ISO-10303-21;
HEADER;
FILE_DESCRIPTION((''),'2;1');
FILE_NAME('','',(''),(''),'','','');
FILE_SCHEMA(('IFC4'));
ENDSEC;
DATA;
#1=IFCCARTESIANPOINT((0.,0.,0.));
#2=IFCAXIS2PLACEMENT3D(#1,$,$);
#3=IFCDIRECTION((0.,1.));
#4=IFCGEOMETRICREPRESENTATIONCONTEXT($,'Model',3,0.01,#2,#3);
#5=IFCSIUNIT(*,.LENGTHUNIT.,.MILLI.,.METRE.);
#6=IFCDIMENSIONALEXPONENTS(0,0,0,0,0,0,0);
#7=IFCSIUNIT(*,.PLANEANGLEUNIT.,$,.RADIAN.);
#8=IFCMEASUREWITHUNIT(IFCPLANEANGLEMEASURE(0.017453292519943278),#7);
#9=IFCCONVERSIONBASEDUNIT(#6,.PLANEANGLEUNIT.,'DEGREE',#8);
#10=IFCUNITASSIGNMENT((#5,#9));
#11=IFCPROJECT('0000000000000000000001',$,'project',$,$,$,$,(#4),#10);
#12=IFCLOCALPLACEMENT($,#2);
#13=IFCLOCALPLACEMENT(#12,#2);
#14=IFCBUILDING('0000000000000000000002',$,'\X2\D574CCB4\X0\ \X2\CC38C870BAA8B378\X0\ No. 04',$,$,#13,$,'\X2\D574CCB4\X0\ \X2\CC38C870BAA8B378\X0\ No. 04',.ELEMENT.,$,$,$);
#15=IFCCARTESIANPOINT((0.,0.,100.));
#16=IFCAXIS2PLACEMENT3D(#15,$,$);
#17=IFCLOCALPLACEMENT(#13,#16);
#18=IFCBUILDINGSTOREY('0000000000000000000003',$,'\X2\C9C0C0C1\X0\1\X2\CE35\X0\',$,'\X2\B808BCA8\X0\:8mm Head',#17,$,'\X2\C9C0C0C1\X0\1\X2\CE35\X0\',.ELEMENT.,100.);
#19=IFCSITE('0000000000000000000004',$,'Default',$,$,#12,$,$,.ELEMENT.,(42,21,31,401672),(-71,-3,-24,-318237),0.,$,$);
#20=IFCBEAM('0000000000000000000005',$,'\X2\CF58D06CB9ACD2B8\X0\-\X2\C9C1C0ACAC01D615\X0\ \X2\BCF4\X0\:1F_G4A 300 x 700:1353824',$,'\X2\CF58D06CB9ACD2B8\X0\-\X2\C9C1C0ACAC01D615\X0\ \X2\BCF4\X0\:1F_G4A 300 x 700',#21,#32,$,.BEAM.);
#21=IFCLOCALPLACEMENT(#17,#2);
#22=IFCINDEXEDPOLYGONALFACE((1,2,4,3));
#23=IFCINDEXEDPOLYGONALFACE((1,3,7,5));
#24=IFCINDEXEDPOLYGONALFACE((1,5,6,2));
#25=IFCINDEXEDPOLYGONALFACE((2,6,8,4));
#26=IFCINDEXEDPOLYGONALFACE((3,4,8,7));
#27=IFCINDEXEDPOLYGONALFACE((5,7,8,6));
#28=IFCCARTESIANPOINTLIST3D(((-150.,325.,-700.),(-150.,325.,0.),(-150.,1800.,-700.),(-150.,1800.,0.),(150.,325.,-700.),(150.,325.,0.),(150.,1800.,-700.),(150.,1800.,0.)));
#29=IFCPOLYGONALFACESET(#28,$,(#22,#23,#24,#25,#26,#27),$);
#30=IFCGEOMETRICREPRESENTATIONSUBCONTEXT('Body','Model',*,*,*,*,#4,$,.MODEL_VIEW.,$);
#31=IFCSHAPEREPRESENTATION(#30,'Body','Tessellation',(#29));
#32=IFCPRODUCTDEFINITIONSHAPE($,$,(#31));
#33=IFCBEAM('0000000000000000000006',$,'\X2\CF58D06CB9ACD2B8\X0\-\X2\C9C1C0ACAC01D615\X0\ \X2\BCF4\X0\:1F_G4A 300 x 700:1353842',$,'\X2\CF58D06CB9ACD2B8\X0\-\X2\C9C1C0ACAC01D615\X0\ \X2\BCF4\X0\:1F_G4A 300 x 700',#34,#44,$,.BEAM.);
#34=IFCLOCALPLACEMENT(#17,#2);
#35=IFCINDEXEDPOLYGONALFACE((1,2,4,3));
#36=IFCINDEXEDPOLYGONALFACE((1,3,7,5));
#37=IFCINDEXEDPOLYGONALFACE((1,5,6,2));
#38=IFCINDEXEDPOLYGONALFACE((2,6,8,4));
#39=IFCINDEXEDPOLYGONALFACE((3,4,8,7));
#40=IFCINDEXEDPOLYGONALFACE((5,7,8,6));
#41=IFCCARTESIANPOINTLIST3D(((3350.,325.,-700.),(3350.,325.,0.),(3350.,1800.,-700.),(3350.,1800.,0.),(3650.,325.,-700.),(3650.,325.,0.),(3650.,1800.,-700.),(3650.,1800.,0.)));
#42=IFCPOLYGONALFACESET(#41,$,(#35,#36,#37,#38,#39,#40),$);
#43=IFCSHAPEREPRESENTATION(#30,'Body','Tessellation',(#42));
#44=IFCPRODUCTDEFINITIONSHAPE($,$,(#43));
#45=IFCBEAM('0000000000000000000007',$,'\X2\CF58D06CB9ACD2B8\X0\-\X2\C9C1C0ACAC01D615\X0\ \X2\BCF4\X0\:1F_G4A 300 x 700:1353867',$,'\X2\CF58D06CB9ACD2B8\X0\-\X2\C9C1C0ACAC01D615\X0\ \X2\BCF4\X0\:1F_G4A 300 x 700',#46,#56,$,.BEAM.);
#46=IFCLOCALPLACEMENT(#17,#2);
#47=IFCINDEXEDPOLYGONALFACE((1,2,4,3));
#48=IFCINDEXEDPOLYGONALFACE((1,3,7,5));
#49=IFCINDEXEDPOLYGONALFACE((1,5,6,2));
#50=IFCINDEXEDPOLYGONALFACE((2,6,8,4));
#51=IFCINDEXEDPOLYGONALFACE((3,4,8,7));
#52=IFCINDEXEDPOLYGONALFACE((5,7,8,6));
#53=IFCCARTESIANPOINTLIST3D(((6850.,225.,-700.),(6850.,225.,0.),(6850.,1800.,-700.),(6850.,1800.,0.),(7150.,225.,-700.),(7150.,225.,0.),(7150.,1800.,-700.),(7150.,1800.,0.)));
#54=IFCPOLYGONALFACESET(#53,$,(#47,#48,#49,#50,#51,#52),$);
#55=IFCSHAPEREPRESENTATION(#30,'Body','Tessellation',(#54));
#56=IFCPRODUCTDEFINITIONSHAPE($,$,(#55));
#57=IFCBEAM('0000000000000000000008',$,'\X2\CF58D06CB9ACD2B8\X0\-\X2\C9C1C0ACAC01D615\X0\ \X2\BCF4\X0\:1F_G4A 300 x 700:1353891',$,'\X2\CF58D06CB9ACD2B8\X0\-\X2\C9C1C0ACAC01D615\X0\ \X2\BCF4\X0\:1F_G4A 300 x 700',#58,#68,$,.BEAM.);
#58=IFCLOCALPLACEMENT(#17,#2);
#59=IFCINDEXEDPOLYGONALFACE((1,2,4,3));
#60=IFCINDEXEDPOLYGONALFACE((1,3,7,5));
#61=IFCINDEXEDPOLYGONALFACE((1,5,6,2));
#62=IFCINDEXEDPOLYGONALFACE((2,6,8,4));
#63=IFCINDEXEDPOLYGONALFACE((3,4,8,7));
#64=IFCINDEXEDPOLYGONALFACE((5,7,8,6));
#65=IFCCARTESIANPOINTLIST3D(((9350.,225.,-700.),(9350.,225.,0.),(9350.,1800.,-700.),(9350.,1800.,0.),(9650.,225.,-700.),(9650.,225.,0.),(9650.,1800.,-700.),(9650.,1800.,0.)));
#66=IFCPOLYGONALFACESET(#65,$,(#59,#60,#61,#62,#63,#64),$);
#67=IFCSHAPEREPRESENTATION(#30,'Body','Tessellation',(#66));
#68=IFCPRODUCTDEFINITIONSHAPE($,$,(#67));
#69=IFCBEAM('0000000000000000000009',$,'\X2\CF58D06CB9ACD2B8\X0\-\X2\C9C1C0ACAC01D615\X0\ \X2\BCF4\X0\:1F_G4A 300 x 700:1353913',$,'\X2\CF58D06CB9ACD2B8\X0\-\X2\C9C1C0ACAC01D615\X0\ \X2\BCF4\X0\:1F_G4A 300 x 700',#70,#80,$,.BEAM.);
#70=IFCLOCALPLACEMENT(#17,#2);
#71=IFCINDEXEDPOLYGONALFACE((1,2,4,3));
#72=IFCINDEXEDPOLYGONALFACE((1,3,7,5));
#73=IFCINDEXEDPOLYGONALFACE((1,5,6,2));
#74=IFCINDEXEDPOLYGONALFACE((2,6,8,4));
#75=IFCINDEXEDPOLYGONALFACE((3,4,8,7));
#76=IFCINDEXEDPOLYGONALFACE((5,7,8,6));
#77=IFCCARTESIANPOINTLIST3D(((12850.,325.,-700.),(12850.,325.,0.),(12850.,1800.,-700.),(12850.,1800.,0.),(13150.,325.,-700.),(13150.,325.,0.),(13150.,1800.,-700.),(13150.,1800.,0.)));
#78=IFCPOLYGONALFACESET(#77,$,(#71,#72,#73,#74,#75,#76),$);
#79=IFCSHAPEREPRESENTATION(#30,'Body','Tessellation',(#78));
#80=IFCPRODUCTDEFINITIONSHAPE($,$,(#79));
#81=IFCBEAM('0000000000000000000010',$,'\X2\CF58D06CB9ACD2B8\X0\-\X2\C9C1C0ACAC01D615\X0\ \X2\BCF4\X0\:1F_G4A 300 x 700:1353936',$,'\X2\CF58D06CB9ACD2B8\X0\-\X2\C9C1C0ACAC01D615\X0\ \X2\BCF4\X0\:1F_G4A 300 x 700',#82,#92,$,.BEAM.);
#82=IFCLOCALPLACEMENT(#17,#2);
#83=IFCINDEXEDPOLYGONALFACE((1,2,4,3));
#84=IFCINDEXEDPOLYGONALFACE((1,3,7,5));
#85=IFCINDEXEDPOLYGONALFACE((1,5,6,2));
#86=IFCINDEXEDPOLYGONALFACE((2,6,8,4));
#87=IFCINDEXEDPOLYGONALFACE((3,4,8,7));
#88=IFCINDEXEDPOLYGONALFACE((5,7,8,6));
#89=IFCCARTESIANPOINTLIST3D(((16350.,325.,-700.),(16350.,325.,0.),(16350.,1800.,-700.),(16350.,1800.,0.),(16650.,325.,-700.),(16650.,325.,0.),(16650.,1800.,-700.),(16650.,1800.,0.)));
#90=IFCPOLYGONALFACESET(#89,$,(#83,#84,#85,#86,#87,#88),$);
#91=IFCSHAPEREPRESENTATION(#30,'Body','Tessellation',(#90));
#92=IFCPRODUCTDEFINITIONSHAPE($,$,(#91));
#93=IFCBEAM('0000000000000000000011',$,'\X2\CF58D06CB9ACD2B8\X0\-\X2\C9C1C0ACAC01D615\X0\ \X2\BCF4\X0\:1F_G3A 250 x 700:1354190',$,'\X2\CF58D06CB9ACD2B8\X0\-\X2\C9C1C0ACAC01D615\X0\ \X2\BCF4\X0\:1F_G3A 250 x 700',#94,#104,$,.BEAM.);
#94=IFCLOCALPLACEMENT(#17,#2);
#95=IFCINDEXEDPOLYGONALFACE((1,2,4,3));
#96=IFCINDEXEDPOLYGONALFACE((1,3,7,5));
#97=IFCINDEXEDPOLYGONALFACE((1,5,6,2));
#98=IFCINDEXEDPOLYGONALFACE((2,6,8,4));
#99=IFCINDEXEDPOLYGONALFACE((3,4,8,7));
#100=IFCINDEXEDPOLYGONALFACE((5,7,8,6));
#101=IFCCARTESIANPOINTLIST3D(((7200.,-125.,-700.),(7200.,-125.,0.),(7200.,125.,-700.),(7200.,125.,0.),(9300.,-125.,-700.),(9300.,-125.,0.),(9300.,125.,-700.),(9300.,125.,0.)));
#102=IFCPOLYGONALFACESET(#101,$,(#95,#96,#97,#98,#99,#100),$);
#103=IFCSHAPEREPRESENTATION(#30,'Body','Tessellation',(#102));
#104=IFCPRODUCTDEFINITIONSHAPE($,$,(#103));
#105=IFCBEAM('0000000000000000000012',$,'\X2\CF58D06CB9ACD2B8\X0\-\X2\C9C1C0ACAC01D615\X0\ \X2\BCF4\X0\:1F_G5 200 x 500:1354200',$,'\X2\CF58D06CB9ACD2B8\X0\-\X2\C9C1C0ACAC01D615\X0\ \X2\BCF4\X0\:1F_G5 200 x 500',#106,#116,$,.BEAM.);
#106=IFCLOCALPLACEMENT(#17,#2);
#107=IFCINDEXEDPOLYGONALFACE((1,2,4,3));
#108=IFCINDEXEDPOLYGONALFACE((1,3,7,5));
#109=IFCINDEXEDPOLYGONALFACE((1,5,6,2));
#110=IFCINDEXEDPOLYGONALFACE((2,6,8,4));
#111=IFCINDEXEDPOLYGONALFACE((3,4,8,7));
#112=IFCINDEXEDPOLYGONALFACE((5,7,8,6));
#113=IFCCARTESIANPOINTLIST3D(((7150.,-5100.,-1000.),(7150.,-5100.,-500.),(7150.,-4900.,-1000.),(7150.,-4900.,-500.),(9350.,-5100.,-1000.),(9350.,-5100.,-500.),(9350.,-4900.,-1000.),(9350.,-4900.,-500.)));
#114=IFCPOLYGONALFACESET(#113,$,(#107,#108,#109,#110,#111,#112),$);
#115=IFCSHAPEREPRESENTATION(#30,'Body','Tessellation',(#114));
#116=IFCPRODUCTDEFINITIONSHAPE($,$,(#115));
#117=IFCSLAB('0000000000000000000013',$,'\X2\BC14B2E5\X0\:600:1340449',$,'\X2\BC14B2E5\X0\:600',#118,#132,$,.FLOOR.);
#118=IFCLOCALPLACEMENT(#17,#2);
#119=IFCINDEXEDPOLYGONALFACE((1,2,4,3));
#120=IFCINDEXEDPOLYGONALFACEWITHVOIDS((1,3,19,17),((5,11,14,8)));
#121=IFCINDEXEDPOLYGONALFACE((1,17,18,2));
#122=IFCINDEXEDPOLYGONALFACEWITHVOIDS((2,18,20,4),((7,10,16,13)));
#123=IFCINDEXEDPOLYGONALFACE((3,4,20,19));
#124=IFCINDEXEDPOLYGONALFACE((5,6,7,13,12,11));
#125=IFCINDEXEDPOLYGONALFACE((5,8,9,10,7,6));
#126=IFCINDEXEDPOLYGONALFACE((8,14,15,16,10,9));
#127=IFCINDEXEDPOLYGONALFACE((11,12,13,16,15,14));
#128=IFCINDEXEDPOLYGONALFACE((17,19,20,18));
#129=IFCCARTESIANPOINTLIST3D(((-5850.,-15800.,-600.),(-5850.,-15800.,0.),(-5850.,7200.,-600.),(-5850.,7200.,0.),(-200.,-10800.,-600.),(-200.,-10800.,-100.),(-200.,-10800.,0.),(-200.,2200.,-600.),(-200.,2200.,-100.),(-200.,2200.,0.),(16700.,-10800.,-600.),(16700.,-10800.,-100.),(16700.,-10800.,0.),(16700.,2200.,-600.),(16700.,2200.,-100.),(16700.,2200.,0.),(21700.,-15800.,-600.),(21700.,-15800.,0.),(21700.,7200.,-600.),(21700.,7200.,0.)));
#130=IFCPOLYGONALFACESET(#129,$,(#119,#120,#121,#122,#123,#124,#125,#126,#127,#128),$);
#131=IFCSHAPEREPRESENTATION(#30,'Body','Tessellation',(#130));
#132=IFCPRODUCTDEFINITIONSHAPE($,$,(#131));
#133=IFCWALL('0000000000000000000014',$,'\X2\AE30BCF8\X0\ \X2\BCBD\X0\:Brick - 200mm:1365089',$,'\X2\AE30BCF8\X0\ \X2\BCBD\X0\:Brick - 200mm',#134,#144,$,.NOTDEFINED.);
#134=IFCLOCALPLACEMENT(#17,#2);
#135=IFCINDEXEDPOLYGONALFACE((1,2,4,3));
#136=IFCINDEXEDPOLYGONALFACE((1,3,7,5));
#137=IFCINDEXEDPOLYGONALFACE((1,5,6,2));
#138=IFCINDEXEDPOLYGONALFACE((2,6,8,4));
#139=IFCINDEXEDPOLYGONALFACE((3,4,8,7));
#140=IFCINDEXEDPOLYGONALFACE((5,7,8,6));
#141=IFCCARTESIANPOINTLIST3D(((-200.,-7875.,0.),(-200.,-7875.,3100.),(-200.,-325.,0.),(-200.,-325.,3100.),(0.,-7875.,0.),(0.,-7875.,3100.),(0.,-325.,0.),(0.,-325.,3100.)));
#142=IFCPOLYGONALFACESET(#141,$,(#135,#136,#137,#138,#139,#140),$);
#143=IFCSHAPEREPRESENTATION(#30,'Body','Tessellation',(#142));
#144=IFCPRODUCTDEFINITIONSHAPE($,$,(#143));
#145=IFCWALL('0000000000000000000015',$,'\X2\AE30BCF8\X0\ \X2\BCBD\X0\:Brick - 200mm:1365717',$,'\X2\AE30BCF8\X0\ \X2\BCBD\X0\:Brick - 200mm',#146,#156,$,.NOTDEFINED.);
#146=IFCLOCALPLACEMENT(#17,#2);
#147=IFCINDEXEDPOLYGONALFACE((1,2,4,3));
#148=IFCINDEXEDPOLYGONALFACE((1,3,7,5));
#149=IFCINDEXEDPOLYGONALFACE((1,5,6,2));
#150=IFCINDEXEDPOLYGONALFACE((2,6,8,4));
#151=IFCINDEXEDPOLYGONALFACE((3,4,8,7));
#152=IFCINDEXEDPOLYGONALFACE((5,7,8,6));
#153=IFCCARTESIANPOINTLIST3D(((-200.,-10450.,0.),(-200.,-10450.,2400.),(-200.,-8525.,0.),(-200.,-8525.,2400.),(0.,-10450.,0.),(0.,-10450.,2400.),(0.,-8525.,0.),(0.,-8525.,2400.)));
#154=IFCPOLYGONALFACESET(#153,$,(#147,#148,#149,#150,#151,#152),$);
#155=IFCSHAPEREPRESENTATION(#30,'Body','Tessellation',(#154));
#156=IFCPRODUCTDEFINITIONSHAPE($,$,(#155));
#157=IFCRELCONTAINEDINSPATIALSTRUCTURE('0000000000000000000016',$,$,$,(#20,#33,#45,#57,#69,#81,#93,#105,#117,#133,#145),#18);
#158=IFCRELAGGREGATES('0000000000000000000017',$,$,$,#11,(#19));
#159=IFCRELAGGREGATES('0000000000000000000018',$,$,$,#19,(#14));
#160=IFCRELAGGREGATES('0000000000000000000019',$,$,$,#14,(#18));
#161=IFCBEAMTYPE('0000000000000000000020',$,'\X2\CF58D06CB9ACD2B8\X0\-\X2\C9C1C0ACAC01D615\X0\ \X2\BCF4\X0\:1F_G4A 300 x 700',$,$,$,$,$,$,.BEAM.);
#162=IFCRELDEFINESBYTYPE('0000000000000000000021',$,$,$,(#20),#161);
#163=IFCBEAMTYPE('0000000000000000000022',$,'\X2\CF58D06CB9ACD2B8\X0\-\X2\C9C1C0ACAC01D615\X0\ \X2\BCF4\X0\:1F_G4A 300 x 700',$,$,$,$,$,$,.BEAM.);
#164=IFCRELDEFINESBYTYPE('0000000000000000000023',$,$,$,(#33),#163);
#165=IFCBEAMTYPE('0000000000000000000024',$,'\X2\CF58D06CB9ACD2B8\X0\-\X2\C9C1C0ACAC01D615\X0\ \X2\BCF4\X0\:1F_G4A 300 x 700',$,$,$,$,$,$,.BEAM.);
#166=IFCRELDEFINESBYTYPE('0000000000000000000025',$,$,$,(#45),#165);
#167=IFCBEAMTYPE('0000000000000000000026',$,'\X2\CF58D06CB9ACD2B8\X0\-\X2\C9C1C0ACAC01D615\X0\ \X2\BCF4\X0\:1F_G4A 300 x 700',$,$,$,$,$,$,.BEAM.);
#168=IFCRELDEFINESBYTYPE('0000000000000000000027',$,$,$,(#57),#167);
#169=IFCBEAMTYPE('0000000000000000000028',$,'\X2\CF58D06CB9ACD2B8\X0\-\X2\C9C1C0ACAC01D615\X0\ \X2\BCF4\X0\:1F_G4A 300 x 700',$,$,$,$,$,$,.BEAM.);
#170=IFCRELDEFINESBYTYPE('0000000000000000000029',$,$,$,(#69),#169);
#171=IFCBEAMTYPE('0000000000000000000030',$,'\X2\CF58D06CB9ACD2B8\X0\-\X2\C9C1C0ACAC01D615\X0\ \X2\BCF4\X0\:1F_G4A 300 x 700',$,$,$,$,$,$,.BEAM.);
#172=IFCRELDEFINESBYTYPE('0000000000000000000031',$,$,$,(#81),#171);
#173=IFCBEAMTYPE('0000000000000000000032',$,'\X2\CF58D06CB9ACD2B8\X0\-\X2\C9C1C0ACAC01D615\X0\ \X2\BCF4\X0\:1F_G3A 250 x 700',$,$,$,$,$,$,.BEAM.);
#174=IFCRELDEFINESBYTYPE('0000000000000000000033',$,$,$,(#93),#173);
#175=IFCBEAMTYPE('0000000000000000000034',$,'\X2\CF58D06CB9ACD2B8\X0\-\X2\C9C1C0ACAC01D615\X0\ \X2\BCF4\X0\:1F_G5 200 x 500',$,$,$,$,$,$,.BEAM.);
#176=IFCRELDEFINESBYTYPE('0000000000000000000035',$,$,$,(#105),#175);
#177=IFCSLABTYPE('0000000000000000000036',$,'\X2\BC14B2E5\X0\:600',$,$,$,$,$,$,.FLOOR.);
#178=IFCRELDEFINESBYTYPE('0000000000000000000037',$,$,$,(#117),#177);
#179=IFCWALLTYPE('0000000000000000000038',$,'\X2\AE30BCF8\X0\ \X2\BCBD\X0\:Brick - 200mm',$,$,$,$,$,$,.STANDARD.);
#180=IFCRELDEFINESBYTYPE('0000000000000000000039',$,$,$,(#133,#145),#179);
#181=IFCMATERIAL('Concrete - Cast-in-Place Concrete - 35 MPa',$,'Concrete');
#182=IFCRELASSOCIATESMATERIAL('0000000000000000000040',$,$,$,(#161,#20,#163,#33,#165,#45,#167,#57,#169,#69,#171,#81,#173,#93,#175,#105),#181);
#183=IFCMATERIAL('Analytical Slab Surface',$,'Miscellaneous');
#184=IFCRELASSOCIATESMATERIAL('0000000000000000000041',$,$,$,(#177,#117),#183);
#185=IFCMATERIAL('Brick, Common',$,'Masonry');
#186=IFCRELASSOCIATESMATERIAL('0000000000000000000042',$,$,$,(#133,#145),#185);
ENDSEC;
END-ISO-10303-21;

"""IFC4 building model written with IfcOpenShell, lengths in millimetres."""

from ifc_helpers import new_model, entity, si_unit, converted_unit, direction, frame, origin, place, context, subcontext, project, spatial, indexed_curve, outline, extrude, source, transform, mapped, material, type_object, type_shapes, element, save


model = new_model("IFC4")

# Units and contexts
model_context = context("Model", 3, precision=0.01, world=origin(), true_north=direction((0.0, 1.0)))
body_context = subcontext(model_context, "Body", "Model", "MODEL_VIEW")
ifc_project = project(units=[si_unit("LENGTHUNIT", "METRE", prefix="MILLI"), converted_unit("PLANEANGLEUNIT", "DEGREE", entity("IfcPlaneAngleMeasure", 0.017453292519943278), si_unit("PLANEANGLEUNIT", "RADIAN"), dimensions=[0, 0, 0, 0, 0, 0, 0])], contexts=[model_context])

# Site, building, storey
site_placement = place(None, origin())
site = spatial("IfcSite", under=ifc_project, at=site_placement, Name="Default", CompositionType="ELEMENT", RefLatitude=(42, 21, 31, 401672), RefLongitude=(-71, -3, -24, -318237), RefElevation=0.0)
building_placement = place(site_placement, origin())
building = spatial("IfcBuilding", under=site, at=building_placement, Name="해체 참조모델 No. 04", LongName="해체 참조모델 No. 04", CompositionType="ELEMENT")
storey_placement = place(building_placement, frame((0.0, 0.0, 100.0)))
storey = spatial("IfcBuildingStorey", under=building, at=storey_placement, Name="지상1층", ObjectType="레벨:8mm Head", LongName="지상1층", CompositionType="ELEMENT", Elevation=100.0)

# Beams
ifc_material_1 = material(Name="Concrete - Cast-in-Place Concrete - 35 MPa", Category="Concrete")
beam_type_1 = type_object("IfcBeamType", Name="콘크리트-직사각형 보:1F_G4A 300 x 700", PredefinedType="BEAM", material=ifc_material_1)
shared_shape_1 = source(origin(), body_context, "Body", "SweptSolid", [
    extrude(outline(indexed_curve([(-150.0, -350.0), (150.0, -350.0), (150.0, 350.0), (-150.0, 350.0), (-150.0, -350.0)], self_intersect=False)), frame((0.0, 325.0, -250.0), z_axis=(0.0, 1.0, 0.0), x_axis=(-1.0, 0.0, 0.0)), (0.0, 0.0, 1.0), 1475.0),
])
type_shapes(beam_type_1, [shared_shape_1])
beam_1_placement = place(storey_placement, frame((0.0, 0.0, -100.0)))
element("IfcBeam", 1, at=beam_1_placement, inside=storey, type_object=beam_type_1, material=ifc_material_1, Name="콘크리트-직사각형 보:1F_G4A 300 x 700:1353824", ObjectType="콘크리트-직사각형 보:1F_G4A 300 x 700", PredefinedType="BEAM", context=body_context, shape_type="MappedRepresentation", body=[
    mapped(shared_shape_1, transform((0.0, 0.0, 0.0), scale=1.0)),
])
beam_type_2 = type_object("IfcBeamType", Name="콘크리트-직사각형 보:1F_G4A 300 x 700", PredefinedType="BEAM", material=ifc_material_1)
shared_shape_2 = source(origin(), body_context, "Body", "SweptSolid", [
    extrude(outline(indexed_curve([(-150.0, -350.0), (150.0, -350.0), (150.0, 350.0), (-150.0, 350.0), (-150.0, -350.0)], self_intersect=False)), frame((3500.0, 325.0, -250.0), z_axis=(0.0, 1.0, 0.0), x_axis=(-1.0, 0.0, 0.0)), (0.0, 0.0, 1.0), 1475.0),
])
type_shapes(beam_type_2, [shared_shape_2])
beam_2_placement = place(storey_placement, frame((0.0, 0.0, -100.0)))
element("IfcBeam", 2, at=beam_2_placement, inside=storey, type_object=beam_type_2, material=ifc_material_1, Name="콘크리트-직사각형 보:1F_G4A 300 x 700:1353842", ObjectType="콘크리트-직사각형 보:1F_G4A 300 x 700", PredefinedType="BEAM", context=body_context, shape_type="MappedRepresentation", body=[
    mapped(shared_shape_2, transform((0.0, 0.0, 0.0), scale=1.0)),
])
beam_type_3 = type_object("IfcBeamType", Name="콘크리트-직사각형 보:1F_G4A 300 x 700", PredefinedType="BEAM", material=ifc_material_1)
shared_shape_3 = source(origin(), body_context, "Body", "SweptSolid", [
    extrude(outline(indexed_curve([(-150.0, -350.0), (150.0, -350.0), (150.0, 350.0), (-150.0, 350.0), (-150.0, -350.0)], self_intersect=False)), frame((7000.0, 225.0, -250.0), z_axis=(0.0, 1.0, 0.0), x_axis=(-1.0, 0.0, 0.0)), (0.0, 0.0, 1.0), 1575.0),
])
type_shapes(beam_type_3, [shared_shape_3])
beam_3_placement = place(storey_placement, frame((0.0, 0.0, -100.0)))
element("IfcBeam", 3, at=beam_3_placement, inside=storey, type_object=beam_type_3, material=ifc_material_1, Name="콘크리트-직사각형 보:1F_G4A 300 x 700:1353867", ObjectType="콘크리트-직사각형 보:1F_G4A 300 x 700", PredefinedType="BEAM", context=body_context, shape_type="MappedRepresentation", body=[
    mapped(shared_shape_3, transform((0.0, 0.0, 0.0), scale=1.0)),
])
beam_type_4 = type_object("IfcBeamType", Name="콘크리트-직사각형 보:1F_G4A 300 x 700", PredefinedType="BEAM", material=ifc_material_1)
shared_shape_4 = source(origin(), body_context, "Body", "SweptSolid", [
    extrude(outline(indexed_curve([(-150.0, -350.0), (150.0, -350.0), (150.0, 350.0), (-150.0, 350.0), (-150.0, -350.0)], self_intersect=False)), frame((9500.0, 225.0, -250.0), z_axis=(0.0, 1.0, 0.0), x_axis=(-1.0, 0.0, 0.0)), (0.0, 0.0, 1.0), 1575.0),
])
type_shapes(beam_type_4, [shared_shape_4])
beam_4_placement = place(storey_placement, frame((0.0, 0.0, -100.0)))
element("IfcBeam", 4, at=beam_4_placement, inside=storey, type_object=beam_type_4, material=ifc_material_1, Name="콘크리트-직사각형 보:1F_G4A 300 x 700:1353891", ObjectType="콘크리트-직사각형 보:1F_G4A 300 x 700", PredefinedType="BEAM", context=body_context, shape_type="MappedRepresentation", body=[
    mapped(shared_shape_4, transform((0.0, 0.0, 0.0), scale=1.0)),
])
beam_type_5 = type_object("IfcBeamType", Name="콘크리트-직사각형 보:1F_G4A 300 x 700", PredefinedType="BEAM", material=ifc_material_1)
shared_shape_5 = source(origin(), body_context, "Body", "SweptSolid", [
    extrude(outline(indexed_curve([(-150.0, -350.0), (150.0, -350.0), (150.0, 350.0), (-150.0, 350.0), (-150.0, -350.0)], self_intersect=False)), frame((13000.0, 325.0, -250.0), z_axis=(0.0, 1.0, 0.0), x_axis=(-1.0, 0.0, 0.0)), (0.0, 0.0, 1.0), 1475.0),
])
type_shapes(beam_type_5, [shared_shape_5])
beam_5_placement = place(storey_placement, frame((0.0, 0.0, -100.0)))
element("IfcBeam", 5, at=beam_5_placement, inside=storey, type_object=beam_type_5, material=ifc_material_1, Name="콘크리트-직사각형 보:1F_G4A 300 x 700:1353913", ObjectType="콘크리트-직사각형 보:1F_G4A 300 x 700", PredefinedType="BEAM", context=body_context, shape_type="MappedRepresentation", body=[
    mapped(shared_shape_5, transform((0.0, 0.0, 0.0), scale=1.0)),
])
beam_type_6 = type_object("IfcBeamType", Name="콘크리트-직사각형 보:1F_G4A 300 x 700", PredefinedType="BEAM", material=ifc_material_1)
shared_shape_6 = source(origin(), body_context, "Body", "SweptSolid", [
    extrude(outline(indexed_curve([(-150.0, -350.0), (150.0, -350.0), (150.0, 350.0), (-150.0, 350.0), (-150.0, -350.0)], self_intersect=False)), frame((16500.0, 325.0, -250.0), z_axis=(0.0, 1.0, 0.0), x_axis=(-1.0, 0.0, 0.0)), (0.0, 0.0, 1.0), 1475.0),
])
type_shapes(beam_type_6, [shared_shape_6])
beam_6_placement = place(storey_placement, frame((0.0, 0.0, -100.0)))
element("IfcBeam", 6, at=beam_6_placement, inside=storey, type_object=beam_type_6, material=ifc_material_1, Name="콘크리트-직사각형 보:1F_G4A 300 x 700:1353936", ObjectType="콘크리트-직사각형 보:1F_G4A 300 x 700", PredefinedType="BEAM", context=body_context, shape_type="MappedRepresentation", body=[
    mapped(shared_shape_6, transform((0.0, 0.0, 0.0), scale=1.0)),
])
beam_type_7 = type_object("IfcBeamType", Name="콘크리트-직사각형 보:1F_G3A 250 x 700", PredefinedType="BEAM", material=ifc_material_1)
shared_shape_7 = source(origin(), body_context, "Body", "SweptSolid", [
    extrude(outline(indexed_curve([(-350.0, -125.0), (350.0, -125.0), (350.0, 125.0), (-350.0, 125.0), (-350.0, -125.0)], self_intersect=False)), frame((7200.0, 0.0, -250.0), z_axis=(1.0, 0.0, 0.0), x_axis=(0.0, 0.0, -1.0)), (0.0, 0.0, 1.0), 2100.0),
])
type_shapes(beam_type_7, [shared_shape_7])
beam_7_placement = place(storey_placement, frame((0.0, 0.0, -100.0)))
element("IfcBeam", 7, at=beam_7_placement, inside=storey, type_object=beam_type_7, material=ifc_material_1, Name="콘크리트-직사각형 보:1F_G3A 250 x 700:1354190", ObjectType="콘크리트-직사각형 보:1F_G3A 250 x 700", PredefinedType="BEAM", context=body_context, shape_type="MappedRepresentation", body=[
    mapped(shared_shape_7, transform((0.0, 0.0, 0.0), scale=1.0)),
])
beam_type_8 = type_object("IfcBeamType", Name="콘크리트-직사각형 보:1F_G5 200 x 500", PredefinedType="BEAM", material=ifc_material_1)
shared_shape_8 = source(origin(), body_context, "Body", "SweptSolid", [
    extrude(outline(indexed_curve([(-250.0, -100.0), (250.0, -100.0), (250.0, 100.0), (-250.0, 100.0), (-250.0, -100.0)], self_intersect=False)), frame((7150.0, -5000.0, -650.0), z_axis=(1.0, 0.0, 0.0), x_axis=(0.0, 0.0, -1.0)), (0.0, 0.0, 1.0), 2200.0),
])
type_shapes(beam_type_8, [shared_shape_8])
beam_8_placement = place(storey_placement, frame((0.0, 0.0, -100.0)))
element("IfcBeam", 8, at=beam_8_placement, inside=storey, type_object=beam_type_8, material=ifc_material_1, Name="콘크리트-직사각형 보:1F_G5 200 x 500:1354200", ObjectType="콘크리트-직사각형 보:1F_G5 200 x 500", PredefinedType="BEAM", context=body_context, shape_type="MappedRepresentation", body=[
    mapped(shared_shape_8, transform((0.0, 0.0, 0.0), scale=1.0)),
])

# Slab, opening
ifc_material_2 = material(Name="Analytical Slab Surface", Category="Miscellaneous")
slab_type = type_object("IfcSlabType", Name="바닥:600", PredefinedType="FLOOR", material=ifc_material_2)
slab_placement = place(storey_placement, origin())
slab = element("IfcSlab", 9, at=slab_placement, inside=storey, type_object=slab_type, material=ifc_material_2, Name="바닥:600:1340449", ObjectType="바닥:600", PredefinedType="FLOOR", context=body_context, shape_type="SweptSolid", body=[
    extrude(outline(indexed_curve([(-13775.0, -11500.0), (13775.0, -11500.0), (13775.0, 11500.0), (-13775.0, 11500.0), (-13775.0, -11500.0)], self_intersect=False), holes=[indexed_curve([(8125.0, -6500.0), (-8775.0, -6500.0), (-8775.0, 6500.0), (8125.0, 6500.0), (8125.0, -6500.0)], self_intersect=False)]), frame((7925.0, -4300.0, -600.0), z_axis=(0.0, 0.0, 1.0), x_axis=(-1.0, 0.0, 0.0)), (0.0, 0.0, 1.0), 600.0),
])
opening_placement = place(slab_placement, origin())
element("IfcOpeningElement", 10, at=opening_placement, cuts=slab, PredefinedType="OPENING", context=body_context, shape_type="SweptSolid", body=[
    extrude(outline(indexed_curve([(-200.0, 2200.0), (-200.0, -10800.0), (16700.0, -10800.0), (16700.0, 2200.0), (-200.0, 2200.0)], self_intersect=False)), frame((0.0, 0.0, -100.0)), (0.0, 0.0, -1.0), 23000.0),
])

# Walls
ifc_material_3 = material(Name="Brick, Common", Category="Masonry")
wall_type = type_object("IfcWallType", Name="기본 벽:Brick - 200mm", PredefinedType="STANDARD")
wall_1_placement = place(storey_placement, frame((-100.0, -7875.0, 0.0), z_axis=(0.0, 0.0, 1.0), x_axis=(0.0, 1.0, 0.0)))
element("IfcWall", 11, at=wall_1_placement, inside=storey, type_object=wall_type, material=ifc_material_3, Name="기본 벽:Brick - 200mm:1365089", ObjectType="기본 벽:Brick - 200mm", PredefinedType="NOTDEFINED", context=body_context, shape_type="SweptSolid", body=[
    extrude(outline(indexed_curve([(7550.0, 100.0), (0.0, 100.0), (0.0, -100.0), (7550.0, -100.0), (7550.0, 100.0)], self_intersect=False)), origin(), (0.0, 0.0, 1.0), 3100.0),
])
wall_2_placement = place(storey_placement, frame((-100.0, -8525.0, 0.0), z_axis=(0.0, 0.0, 1.0), x_axis=(0.0, -1.0, 0.0)))
element("IfcWall", 12, at=wall_2_placement, inside=storey, type_object=wall_type, material=ifc_material_3, Name="기본 벽:Brick - 200mm:1365717", ObjectType="기본 벽:Brick - 200mm", PredefinedType="NOTDEFINED", context=body_context, shape_type="SweptSolid", body=[
    extrude(outline(indexed_curve([(1925.0, 100.0), (0.0, 100.0), (0.0, -100.0), (1925.0, -100.0), (1925.0, 100.0)], self_intersect=False)), origin(), (0.0, 0.0, 1.0), 2400.0),
])

save(model, "model.ifc")
